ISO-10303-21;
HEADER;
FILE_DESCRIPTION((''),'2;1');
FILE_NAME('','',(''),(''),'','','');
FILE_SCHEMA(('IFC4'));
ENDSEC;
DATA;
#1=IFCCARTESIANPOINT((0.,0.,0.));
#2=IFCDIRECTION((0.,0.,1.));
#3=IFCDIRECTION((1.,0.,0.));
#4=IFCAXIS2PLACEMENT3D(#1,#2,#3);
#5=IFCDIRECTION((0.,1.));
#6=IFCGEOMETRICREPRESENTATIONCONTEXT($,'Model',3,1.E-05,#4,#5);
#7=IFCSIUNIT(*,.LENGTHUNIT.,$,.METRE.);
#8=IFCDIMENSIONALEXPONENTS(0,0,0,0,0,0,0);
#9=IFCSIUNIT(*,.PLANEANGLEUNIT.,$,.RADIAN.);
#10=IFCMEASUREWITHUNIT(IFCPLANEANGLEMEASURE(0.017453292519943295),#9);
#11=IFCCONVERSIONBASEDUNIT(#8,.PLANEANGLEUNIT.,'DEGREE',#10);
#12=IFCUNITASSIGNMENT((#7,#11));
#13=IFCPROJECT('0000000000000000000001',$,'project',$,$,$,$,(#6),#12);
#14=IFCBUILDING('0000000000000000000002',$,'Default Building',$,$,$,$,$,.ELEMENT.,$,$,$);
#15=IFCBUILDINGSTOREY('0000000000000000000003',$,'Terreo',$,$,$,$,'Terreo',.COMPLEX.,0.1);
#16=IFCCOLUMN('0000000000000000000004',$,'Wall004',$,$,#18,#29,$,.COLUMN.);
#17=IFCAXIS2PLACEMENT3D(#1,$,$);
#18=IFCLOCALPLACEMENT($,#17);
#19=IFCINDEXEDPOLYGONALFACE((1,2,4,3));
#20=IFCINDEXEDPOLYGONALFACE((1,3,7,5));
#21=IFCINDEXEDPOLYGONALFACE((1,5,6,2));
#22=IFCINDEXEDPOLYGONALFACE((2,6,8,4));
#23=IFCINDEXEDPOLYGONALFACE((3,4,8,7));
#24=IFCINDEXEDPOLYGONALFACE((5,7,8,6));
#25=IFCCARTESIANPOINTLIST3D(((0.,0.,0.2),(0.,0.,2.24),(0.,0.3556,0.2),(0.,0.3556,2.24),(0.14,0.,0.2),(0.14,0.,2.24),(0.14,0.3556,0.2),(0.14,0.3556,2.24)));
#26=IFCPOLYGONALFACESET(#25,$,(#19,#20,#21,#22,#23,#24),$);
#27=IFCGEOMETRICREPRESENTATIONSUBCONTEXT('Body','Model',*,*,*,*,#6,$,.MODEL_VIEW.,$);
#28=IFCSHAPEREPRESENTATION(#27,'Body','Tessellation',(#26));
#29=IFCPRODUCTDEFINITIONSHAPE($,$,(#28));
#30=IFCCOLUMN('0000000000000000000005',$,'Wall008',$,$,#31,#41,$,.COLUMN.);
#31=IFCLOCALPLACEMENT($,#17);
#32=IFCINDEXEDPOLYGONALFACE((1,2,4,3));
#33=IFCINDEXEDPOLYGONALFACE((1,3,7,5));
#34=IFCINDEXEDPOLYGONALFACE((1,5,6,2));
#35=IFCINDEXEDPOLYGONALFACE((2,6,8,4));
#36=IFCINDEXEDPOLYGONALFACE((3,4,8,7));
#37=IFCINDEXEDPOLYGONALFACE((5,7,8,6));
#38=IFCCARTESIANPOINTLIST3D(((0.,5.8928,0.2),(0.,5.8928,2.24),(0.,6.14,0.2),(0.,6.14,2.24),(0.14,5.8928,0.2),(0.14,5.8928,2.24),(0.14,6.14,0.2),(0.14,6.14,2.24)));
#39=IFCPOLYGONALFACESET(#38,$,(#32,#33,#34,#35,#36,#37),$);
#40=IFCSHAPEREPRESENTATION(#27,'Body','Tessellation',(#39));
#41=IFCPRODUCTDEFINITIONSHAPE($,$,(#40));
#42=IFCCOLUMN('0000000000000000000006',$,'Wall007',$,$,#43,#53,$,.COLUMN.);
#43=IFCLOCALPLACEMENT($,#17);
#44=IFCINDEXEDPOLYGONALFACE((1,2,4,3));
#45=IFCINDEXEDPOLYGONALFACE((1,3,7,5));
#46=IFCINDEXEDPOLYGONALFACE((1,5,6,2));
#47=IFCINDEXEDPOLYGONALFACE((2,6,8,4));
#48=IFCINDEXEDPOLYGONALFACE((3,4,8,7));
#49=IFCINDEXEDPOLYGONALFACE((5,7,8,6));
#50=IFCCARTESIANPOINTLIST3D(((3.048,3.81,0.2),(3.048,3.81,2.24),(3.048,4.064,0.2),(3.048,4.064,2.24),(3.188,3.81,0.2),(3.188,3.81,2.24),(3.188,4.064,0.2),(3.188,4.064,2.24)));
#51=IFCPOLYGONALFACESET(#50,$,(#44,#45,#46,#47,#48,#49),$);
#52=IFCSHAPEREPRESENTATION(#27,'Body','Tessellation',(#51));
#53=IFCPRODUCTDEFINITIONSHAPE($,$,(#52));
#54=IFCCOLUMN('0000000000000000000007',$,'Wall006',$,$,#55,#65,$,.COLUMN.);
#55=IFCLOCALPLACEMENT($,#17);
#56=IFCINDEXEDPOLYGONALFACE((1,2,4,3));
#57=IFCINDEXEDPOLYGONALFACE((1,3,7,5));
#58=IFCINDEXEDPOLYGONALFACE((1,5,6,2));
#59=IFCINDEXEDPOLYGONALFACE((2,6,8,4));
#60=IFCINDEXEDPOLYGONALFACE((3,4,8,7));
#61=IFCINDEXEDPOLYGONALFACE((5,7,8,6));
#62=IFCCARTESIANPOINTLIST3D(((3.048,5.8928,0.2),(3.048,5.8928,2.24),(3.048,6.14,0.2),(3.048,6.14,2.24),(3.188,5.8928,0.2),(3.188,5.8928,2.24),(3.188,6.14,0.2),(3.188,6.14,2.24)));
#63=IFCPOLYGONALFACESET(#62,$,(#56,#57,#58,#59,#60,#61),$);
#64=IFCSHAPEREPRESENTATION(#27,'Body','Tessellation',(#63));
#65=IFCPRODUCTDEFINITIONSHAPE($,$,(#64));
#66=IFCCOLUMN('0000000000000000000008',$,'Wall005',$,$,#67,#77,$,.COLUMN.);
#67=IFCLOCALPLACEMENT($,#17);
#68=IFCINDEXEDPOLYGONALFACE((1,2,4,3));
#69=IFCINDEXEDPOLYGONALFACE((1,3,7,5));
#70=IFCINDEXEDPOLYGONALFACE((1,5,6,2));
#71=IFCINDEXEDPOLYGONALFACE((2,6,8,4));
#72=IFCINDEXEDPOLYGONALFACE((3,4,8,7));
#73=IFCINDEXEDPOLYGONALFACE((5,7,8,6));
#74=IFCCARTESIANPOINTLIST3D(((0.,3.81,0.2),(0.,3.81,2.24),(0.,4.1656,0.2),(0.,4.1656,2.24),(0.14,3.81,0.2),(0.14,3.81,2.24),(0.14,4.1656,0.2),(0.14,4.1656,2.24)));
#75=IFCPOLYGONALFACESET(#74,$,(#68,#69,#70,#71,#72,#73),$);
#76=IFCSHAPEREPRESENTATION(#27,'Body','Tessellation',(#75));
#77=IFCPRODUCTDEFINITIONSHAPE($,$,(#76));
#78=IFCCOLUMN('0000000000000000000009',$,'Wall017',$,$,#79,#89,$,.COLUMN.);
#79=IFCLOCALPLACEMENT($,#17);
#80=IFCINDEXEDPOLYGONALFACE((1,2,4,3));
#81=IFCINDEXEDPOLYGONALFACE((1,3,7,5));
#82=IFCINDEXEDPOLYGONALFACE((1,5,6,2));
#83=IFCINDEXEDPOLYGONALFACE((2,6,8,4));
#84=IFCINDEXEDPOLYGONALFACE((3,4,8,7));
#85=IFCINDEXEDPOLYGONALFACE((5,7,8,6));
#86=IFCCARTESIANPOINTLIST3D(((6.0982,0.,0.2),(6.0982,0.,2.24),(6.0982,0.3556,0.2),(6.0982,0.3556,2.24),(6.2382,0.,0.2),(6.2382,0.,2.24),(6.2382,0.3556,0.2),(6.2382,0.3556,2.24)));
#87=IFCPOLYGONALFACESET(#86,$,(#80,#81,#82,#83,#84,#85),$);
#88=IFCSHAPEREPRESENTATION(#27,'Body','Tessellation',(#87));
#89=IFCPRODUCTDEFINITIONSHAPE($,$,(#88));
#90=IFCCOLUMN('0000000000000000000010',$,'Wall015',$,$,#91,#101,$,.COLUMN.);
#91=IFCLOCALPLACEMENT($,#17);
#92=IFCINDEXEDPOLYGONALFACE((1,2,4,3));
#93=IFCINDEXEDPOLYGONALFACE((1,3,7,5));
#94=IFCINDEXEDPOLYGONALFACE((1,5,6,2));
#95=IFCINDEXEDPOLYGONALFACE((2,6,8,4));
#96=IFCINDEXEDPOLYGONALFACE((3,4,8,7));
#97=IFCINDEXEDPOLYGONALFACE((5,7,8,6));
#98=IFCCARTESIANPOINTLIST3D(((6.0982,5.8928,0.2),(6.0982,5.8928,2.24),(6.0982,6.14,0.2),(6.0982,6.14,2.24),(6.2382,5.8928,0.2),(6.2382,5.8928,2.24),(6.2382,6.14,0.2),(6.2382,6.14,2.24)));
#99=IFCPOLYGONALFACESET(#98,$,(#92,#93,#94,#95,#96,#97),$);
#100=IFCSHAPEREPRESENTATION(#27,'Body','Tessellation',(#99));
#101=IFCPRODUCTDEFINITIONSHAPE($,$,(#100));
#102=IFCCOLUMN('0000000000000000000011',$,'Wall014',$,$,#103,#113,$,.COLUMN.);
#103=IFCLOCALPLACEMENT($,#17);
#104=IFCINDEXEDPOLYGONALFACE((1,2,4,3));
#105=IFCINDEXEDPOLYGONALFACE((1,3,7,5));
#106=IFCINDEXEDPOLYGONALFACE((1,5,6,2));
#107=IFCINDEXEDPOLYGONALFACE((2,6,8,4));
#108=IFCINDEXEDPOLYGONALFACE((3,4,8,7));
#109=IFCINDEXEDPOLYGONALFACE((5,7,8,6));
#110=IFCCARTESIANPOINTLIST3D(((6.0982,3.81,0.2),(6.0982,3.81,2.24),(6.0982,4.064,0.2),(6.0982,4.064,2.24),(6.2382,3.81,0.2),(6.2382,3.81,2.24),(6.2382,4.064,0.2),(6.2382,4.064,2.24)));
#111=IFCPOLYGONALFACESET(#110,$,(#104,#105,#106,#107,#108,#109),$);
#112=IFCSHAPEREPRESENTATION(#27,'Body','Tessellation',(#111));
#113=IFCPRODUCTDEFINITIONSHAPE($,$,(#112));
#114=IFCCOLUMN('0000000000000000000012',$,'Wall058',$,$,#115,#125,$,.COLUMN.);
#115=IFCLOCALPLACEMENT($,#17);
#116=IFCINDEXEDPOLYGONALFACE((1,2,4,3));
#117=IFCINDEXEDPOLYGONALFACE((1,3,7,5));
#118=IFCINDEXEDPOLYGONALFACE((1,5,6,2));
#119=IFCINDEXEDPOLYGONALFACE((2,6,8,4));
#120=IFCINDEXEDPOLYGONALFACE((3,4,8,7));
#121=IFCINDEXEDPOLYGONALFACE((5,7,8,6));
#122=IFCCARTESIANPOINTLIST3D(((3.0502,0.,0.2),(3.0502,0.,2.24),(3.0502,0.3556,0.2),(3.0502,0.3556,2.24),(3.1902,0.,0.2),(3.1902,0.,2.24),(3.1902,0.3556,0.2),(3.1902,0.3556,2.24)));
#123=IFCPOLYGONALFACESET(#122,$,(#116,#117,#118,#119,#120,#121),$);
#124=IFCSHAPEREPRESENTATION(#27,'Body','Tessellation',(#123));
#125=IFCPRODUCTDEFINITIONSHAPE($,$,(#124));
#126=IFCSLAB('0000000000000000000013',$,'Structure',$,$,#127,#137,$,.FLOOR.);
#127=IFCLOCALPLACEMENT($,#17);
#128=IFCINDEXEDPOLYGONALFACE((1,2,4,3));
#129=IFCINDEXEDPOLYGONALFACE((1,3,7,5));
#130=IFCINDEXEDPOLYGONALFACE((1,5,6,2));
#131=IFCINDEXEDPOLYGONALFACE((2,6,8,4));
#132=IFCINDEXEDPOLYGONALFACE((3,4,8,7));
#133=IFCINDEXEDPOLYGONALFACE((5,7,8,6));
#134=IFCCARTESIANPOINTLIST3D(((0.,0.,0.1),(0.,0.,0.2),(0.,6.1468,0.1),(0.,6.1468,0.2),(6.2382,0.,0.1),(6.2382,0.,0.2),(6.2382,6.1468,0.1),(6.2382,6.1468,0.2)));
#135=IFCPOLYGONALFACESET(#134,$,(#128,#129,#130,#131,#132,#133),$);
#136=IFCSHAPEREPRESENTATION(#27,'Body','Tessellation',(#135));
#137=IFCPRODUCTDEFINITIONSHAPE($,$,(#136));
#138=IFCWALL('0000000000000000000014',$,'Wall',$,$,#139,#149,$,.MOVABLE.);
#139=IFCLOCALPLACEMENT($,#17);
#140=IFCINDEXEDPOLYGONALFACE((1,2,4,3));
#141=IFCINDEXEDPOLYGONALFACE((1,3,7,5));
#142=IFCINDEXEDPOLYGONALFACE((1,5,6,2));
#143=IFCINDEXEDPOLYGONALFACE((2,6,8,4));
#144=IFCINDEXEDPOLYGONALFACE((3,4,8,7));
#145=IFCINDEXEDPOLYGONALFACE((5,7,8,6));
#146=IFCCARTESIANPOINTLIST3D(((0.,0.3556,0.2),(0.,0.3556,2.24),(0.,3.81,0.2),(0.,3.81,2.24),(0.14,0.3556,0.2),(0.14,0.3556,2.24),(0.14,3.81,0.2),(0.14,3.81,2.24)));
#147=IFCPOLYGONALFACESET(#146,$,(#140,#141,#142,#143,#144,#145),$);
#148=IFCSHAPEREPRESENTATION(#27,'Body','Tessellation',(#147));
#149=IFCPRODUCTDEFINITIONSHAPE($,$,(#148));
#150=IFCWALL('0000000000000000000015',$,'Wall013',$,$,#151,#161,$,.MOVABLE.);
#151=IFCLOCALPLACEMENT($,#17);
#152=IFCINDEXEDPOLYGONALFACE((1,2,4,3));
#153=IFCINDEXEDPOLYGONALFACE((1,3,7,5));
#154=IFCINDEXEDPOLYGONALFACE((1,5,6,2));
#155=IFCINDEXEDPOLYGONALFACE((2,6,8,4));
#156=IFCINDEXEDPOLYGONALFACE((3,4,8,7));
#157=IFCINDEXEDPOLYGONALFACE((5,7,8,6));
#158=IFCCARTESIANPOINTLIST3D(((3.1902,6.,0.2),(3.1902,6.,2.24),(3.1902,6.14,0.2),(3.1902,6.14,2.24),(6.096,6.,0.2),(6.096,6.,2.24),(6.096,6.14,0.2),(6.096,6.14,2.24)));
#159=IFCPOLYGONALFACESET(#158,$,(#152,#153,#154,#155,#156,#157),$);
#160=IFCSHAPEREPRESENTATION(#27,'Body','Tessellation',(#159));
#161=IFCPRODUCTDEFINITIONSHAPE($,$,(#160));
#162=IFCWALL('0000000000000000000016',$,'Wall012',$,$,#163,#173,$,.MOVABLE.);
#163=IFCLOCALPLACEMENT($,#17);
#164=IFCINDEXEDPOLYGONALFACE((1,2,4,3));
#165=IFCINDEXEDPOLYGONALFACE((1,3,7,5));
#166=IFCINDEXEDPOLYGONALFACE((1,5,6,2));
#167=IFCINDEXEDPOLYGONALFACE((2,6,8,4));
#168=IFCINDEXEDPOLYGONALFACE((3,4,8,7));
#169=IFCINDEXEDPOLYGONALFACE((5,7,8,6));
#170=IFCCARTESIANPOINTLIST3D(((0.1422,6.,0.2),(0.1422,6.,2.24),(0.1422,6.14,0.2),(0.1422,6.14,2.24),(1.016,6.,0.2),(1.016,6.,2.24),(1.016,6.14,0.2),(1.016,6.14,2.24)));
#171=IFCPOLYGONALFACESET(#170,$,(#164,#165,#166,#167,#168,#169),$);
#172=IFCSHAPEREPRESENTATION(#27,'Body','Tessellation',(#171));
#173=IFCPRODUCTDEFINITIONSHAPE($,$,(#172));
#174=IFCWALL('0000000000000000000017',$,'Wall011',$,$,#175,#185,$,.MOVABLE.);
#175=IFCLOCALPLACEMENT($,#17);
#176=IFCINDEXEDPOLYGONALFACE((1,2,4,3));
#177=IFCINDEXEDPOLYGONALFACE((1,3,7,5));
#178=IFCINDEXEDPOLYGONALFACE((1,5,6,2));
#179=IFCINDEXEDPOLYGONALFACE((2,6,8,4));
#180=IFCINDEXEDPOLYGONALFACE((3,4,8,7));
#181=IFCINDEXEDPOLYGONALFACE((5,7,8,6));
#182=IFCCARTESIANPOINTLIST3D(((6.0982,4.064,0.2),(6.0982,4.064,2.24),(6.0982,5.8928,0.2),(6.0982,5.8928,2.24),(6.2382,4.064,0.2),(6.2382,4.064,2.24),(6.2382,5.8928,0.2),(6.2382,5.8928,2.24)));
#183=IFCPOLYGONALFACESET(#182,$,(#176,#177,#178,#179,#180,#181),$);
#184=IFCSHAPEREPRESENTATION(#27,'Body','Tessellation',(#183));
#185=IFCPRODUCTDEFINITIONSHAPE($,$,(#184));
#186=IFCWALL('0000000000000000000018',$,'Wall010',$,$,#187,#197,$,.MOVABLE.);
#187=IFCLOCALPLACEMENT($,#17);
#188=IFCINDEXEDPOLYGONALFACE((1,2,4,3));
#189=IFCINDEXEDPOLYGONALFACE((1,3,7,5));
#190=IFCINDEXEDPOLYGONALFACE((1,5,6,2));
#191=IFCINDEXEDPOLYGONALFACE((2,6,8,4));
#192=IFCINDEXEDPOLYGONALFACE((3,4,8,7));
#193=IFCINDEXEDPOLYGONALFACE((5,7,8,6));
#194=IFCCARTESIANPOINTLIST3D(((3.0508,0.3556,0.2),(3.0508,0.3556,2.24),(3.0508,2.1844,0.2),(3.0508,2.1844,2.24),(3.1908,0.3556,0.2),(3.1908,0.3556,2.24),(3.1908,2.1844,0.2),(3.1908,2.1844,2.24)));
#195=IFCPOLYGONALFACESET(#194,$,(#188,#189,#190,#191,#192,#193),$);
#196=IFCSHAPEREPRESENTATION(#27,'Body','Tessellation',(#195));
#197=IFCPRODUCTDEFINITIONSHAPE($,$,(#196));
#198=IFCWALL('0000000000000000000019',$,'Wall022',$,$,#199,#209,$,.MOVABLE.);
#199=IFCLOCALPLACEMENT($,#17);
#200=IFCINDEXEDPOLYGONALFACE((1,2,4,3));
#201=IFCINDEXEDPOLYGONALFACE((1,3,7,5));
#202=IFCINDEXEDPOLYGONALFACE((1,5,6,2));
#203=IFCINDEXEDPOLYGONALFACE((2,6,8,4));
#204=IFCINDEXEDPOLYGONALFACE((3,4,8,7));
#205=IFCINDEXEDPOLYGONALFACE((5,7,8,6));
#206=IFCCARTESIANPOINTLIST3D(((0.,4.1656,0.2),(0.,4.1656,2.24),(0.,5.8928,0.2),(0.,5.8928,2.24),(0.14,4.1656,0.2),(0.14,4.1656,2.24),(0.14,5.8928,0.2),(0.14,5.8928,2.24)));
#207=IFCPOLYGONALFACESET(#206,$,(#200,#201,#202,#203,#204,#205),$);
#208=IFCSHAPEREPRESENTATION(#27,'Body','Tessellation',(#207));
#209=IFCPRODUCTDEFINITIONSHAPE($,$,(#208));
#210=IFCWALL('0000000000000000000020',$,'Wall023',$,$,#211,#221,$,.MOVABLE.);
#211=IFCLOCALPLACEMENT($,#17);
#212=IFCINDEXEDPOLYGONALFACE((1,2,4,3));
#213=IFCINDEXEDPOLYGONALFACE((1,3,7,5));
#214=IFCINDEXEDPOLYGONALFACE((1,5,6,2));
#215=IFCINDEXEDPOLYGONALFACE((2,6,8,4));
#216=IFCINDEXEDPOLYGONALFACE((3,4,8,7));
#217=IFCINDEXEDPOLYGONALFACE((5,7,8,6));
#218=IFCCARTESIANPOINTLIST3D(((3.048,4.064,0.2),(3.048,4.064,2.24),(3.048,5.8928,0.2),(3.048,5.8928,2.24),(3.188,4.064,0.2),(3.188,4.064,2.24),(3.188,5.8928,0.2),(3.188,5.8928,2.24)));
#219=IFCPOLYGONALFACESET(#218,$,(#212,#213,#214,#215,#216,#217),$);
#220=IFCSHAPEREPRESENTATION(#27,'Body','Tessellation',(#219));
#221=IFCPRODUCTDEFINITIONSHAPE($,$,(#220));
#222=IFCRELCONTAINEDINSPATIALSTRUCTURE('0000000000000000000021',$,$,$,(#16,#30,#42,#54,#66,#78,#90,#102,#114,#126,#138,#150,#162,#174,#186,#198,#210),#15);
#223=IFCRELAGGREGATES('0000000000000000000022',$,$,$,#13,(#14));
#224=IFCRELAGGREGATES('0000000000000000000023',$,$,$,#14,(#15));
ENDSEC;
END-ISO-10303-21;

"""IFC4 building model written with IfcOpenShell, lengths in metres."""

from ifc_helpers import new_model, entity, si_unit, converted_unit, direction, frame, frame_2d, origin_with_axes, origin_2d_with_axis, place, context, subcontext, project, spatial, rectangle, extrude, element, save


model = new_model("IFC4")

# Units and contexts
model_context = context("Model", 3, precision=1e-05, world=origin_with_axes(), true_north=direction((0.0, 1.0)))
body_context = subcontext(model_context, "Body", "Model", "MODEL_VIEW")
ifc_project = project(units=[si_unit("LENGTHUNIT", "METRE"), converted_unit("PLANEANGLEUNIT", "DEGREE", entity("IfcPlaneAngleMeasure", 0.017453292519943295), si_unit("PLANEANGLEUNIT", "RADIAN"), dimensions=[0, 0, 0, 0, 0, 0, 0])], contexts=[model_context])

# Building, storey
building = spatial("IfcBuilding", under=ifc_project, Name="Default Building", CompositionType="ELEMENT")
storey = spatial("IfcBuildingStorey", under=building, Name="Terreo", LongName="Terreo", CompositionType="COMPLEX", Elevation=0.1)

# Columns
placement = place(None, origin_with_axes())
element("IfcColumn", 1, at=placement, inside=storey, Name="Wall004", PredefinedType="COLUMN", context=body_context, shape_type="SweptSolid", body=[
    extrude(rectangle(XDim=0.3556, YDim=0.14, at=frame_2d((0.0, 0.0), x_axis=(0.0, -1.0))), frame((0.07, 0.1778, 0.2), z_axis=(0.0, 0.0, 1.0), x_axis=(1.0, 0.0, 0.0)), (0.0, 0.0, 1.0), 2.04),
])
element("IfcColumn", 2, at=placement, inside=storey, Name="Wall008", PredefinedType="COLUMN", context=body_context, shape_type="SweptSolid", body=[
    extrude(rectangle(XDim=0.2472, YDim=0.14, at=frame_2d((0.0, 0.0), x_axis=(0.0, -1.0))), frame((0.07, 6.0164, 0.2), z_axis=(0.0, 0.0, 1.0), x_axis=(1.0, 0.0, 0.0)), (0.0, 0.0, 1.0), 2.04),
])
element("IfcColumn", 3, at=placement, inside=storey, Name="Wall007", PredefinedType="COLUMN", context=body_context, shape_type="SweptSolid", body=[
    extrude(rectangle(XDim=0.254, YDim=0.14, at=frame_2d((0.0, 0.0), x_axis=(0.0, -1.0))), frame((3.118, 3.937, 0.2), z_axis=(0.0, 0.0, 1.0), x_axis=(1.0, 0.0, 0.0)), (0.0, 0.0, 1.0), 2.04),
])
element("IfcColumn", 4, at=placement, inside=storey, Name="Wall006", PredefinedType="COLUMN", context=body_context, shape_type="SweptSolid", body=[
    extrude(rectangle(XDim=0.2472, YDim=0.14, at=frame_2d((0.0, 0.0), x_axis=(0.0, -1.0))), frame((3.118, 6.0164, 0.2), z_axis=(0.0, 0.0, 1.0), x_axis=(1.0, 0.0, 0.0)), (0.0, 0.0, 1.0), 2.04),
])
element("IfcColumn", 5, at=placement, inside=storey, Name="Wall005", PredefinedType="COLUMN", context=body_context, shape_type="SweptSolid", body=[
    extrude(rectangle(XDim=0.3556, YDim=0.14, at=frame_2d((0.0, 0.0), x_axis=(0.0, -1.0))), frame((0.07, 3.9878, 0.2), z_axis=(0.0, 0.0, 1.0), x_axis=(1.0, 0.0, 0.0)), (0.0, 0.0, 1.0), 2.04),
])
element("IfcColumn", 6, at=placement, inside=storey, Name="Wall017", PredefinedType="COLUMN", context=body_context, shape_type="SweptSolid", body=[
    extrude(rectangle(XDim=0.3556, YDim=0.14, at=frame_2d((0.0, 0.0), x_axis=(0.0, 1.0))), frame((6.1682, 0.1778, 0.2), z_axis=(0.0, 0.0, 1.0), x_axis=(1.0, 0.0, 0.0)), (0.0, 0.0, 1.0), 2.04),
])
element("IfcColumn", 7, at=placement, inside=storey, Name="Wall015", PredefinedType="COLUMN", context=body_context, shape_type="SweptSolid", body=[
    extrude(rectangle(XDim=0.2472, YDim=0.14, at=frame_2d((0.0, 0.0), x_axis=(0.0, 1.0))), frame((6.1682, 6.0164, 0.2), z_axis=(0.0, 0.0, 1.0), x_axis=(1.0, 0.0, 0.0)), (0.0, 0.0, 1.0), 2.04),
])
element("IfcColumn", 8, at=placement, inside=storey, Name="Wall014", PredefinedType="COLUMN", context=body_context, shape_type="SweptSolid", body=[
    extrude(rectangle(XDim=0.254, YDim=0.14, at=frame_2d((0.0, 0.0), x_axis=(0.0, 1.0))), frame((6.1682, 3.937, 0.2), z_axis=(0.0, 0.0, 1.0), x_axis=(1.0, 0.0, 0.0)), (0.0, 0.0, 1.0), 2.04),
])
element("IfcColumn", 9, at=placement, inside=storey, Name="Wall058", PredefinedType="COLUMN", context=body_context, shape_type="SweptSolid", body=[
    extrude(rectangle(XDim=0.3556, YDim=0.14, at=frame_2d((0.0, 0.0), x_axis=(0.0, 1.0))), frame((3.1202, 0.1778, 0.2), z_axis=(0.0, 0.0, 1.0), x_axis=(1.0, 0.0, 0.0)), (0.0, 0.0, 1.0), 2.04),
])

# Slab
element("IfcSlab", 10, at=placement, inside=storey, Name="Structure", PredefinedType="FLOOR", context=body_context, shape_type="SweptSolid", body=[
    extrude(rectangle(XDim=6.2382, YDim=6.1468, at=origin_2d_with_axis()), frame((3.1191, 3.0734, 0.1), z_axis=(0.0, 0.0, 1.0), x_axis=(1.0, 0.0, 0.0)), (0.0, 0.0, 1.0), 0.1),
])

# Walls
element("IfcWall", 11, at=placement, inside=storey, Name="Wall", PredefinedType="MOVABLE", context=body_context, shape_type="SweptSolid", body=[
    extrude(rectangle(XDim=3.4544, YDim=0.14, at=frame_2d((0.0, 0.0), x_axis=(0.0, -1.0))), frame((0.07, 2.0828, 0.2), z_axis=(0.0, 0.0, 1.0), x_axis=(1.0, 0.0, 0.0)), (0.0, 0.0, 1.0), 2.04),
])
element("IfcWall", 12, at=placement, inside=storey, Name="Wall013", PredefinedType="MOVABLE", context=body_context, shape_type="SweptSolid", body=[
    extrude(rectangle(XDim=2.9058, YDim=0.14, at=frame_2d((0.0, 0.0), x_axis=(-1.0, 0.0))), frame((4.6431, 6.07, 0.2), z_axis=(0.0, 0.0, 1.0), x_axis=(1.0, 0.0, 0.0)), (0.0, 0.0, 1.0), 2.04),
])
element("IfcWall", 13, at=placement, inside=storey, Name="Wall012", PredefinedType="MOVABLE", context=body_context, shape_type="SweptSolid", body=[
    extrude(rectangle(XDim=0.8738, YDim=0.14, at=frame_2d((0.0, 0.0), x_axis=(-1.0, 0.0))), frame((0.5791, 6.07, 0.2), z_axis=(0.0, 0.0, 1.0), x_axis=(1.0, 0.0, 0.0)), (0.0, 0.0, 1.0), 2.04),
])
element("IfcWall", 14, at=placement, inside=storey, Name="Wall011", PredefinedType="MOVABLE", context=body_context, shape_type="SweptSolid", body=[
    extrude(rectangle(XDim=1.8288, YDim=0.14, at=frame_2d((0.0, 0.0), x_axis=(0.0, 1.0))), frame((6.1682, 4.9784, 0.2), z_axis=(0.0, 0.0, 1.0), x_axis=(1.0, 0.0, 0.0)), (0.0, 0.0, 1.0), 2.04),
])
element("IfcWall", 15, at=placement, inside=storey, Name="Wall010", PredefinedType="MOVABLE", context=body_context, shape_type="SweptSolid", body=[
    extrude(rectangle(XDim=1.8288, YDim=0.14, at=frame_2d((0.0, 0.0), x_axis=(0.0, 1.0))), frame((3.1208, 1.27, 0.2), z_axis=(0.0, 0.0, 1.0), x_axis=(1.0, 0.0, 0.0)), (0.0, 0.0, 1.0), 2.04),
])
element("IfcWall", 16, at=placement, inside=storey, Name="Wall022", PredefinedType="MOVABLE", context=body_context, shape_type="SweptSolid", body=[
    extrude(rectangle(XDim=1.7272, YDim=0.14, at=frame_2d((0.0, 0.0), x_axis=(0.0, -1.0))), frame((0.07, 5.0292, 0.2), z_axis=(0.0, 0.0, 1.0), x_axis=(1.0, 0.0, 0.0)), (0.0, 0.0, 1.0), 2.04),
])
element("IfcWall", 17, at=placement, inside=storey, Name="Wall023", PredefinedType="MOVABLE", context=body_context, shape_type="SweptSolid", body=[
    extrude(rectangle(XDim=1.8288, YDim=0.14, at=frame_2d((0.0, 0.0), x_axis=(0.0, -1.0))), frame((3.118, 4.9784, 0.2), z_axis=(0.0, 0.0, 1.0), x_axis=(1.0, 0.0, 0.0)), (0.0, 0.0, 1.0), 2.04),
])

save(model, "model.ifc")
